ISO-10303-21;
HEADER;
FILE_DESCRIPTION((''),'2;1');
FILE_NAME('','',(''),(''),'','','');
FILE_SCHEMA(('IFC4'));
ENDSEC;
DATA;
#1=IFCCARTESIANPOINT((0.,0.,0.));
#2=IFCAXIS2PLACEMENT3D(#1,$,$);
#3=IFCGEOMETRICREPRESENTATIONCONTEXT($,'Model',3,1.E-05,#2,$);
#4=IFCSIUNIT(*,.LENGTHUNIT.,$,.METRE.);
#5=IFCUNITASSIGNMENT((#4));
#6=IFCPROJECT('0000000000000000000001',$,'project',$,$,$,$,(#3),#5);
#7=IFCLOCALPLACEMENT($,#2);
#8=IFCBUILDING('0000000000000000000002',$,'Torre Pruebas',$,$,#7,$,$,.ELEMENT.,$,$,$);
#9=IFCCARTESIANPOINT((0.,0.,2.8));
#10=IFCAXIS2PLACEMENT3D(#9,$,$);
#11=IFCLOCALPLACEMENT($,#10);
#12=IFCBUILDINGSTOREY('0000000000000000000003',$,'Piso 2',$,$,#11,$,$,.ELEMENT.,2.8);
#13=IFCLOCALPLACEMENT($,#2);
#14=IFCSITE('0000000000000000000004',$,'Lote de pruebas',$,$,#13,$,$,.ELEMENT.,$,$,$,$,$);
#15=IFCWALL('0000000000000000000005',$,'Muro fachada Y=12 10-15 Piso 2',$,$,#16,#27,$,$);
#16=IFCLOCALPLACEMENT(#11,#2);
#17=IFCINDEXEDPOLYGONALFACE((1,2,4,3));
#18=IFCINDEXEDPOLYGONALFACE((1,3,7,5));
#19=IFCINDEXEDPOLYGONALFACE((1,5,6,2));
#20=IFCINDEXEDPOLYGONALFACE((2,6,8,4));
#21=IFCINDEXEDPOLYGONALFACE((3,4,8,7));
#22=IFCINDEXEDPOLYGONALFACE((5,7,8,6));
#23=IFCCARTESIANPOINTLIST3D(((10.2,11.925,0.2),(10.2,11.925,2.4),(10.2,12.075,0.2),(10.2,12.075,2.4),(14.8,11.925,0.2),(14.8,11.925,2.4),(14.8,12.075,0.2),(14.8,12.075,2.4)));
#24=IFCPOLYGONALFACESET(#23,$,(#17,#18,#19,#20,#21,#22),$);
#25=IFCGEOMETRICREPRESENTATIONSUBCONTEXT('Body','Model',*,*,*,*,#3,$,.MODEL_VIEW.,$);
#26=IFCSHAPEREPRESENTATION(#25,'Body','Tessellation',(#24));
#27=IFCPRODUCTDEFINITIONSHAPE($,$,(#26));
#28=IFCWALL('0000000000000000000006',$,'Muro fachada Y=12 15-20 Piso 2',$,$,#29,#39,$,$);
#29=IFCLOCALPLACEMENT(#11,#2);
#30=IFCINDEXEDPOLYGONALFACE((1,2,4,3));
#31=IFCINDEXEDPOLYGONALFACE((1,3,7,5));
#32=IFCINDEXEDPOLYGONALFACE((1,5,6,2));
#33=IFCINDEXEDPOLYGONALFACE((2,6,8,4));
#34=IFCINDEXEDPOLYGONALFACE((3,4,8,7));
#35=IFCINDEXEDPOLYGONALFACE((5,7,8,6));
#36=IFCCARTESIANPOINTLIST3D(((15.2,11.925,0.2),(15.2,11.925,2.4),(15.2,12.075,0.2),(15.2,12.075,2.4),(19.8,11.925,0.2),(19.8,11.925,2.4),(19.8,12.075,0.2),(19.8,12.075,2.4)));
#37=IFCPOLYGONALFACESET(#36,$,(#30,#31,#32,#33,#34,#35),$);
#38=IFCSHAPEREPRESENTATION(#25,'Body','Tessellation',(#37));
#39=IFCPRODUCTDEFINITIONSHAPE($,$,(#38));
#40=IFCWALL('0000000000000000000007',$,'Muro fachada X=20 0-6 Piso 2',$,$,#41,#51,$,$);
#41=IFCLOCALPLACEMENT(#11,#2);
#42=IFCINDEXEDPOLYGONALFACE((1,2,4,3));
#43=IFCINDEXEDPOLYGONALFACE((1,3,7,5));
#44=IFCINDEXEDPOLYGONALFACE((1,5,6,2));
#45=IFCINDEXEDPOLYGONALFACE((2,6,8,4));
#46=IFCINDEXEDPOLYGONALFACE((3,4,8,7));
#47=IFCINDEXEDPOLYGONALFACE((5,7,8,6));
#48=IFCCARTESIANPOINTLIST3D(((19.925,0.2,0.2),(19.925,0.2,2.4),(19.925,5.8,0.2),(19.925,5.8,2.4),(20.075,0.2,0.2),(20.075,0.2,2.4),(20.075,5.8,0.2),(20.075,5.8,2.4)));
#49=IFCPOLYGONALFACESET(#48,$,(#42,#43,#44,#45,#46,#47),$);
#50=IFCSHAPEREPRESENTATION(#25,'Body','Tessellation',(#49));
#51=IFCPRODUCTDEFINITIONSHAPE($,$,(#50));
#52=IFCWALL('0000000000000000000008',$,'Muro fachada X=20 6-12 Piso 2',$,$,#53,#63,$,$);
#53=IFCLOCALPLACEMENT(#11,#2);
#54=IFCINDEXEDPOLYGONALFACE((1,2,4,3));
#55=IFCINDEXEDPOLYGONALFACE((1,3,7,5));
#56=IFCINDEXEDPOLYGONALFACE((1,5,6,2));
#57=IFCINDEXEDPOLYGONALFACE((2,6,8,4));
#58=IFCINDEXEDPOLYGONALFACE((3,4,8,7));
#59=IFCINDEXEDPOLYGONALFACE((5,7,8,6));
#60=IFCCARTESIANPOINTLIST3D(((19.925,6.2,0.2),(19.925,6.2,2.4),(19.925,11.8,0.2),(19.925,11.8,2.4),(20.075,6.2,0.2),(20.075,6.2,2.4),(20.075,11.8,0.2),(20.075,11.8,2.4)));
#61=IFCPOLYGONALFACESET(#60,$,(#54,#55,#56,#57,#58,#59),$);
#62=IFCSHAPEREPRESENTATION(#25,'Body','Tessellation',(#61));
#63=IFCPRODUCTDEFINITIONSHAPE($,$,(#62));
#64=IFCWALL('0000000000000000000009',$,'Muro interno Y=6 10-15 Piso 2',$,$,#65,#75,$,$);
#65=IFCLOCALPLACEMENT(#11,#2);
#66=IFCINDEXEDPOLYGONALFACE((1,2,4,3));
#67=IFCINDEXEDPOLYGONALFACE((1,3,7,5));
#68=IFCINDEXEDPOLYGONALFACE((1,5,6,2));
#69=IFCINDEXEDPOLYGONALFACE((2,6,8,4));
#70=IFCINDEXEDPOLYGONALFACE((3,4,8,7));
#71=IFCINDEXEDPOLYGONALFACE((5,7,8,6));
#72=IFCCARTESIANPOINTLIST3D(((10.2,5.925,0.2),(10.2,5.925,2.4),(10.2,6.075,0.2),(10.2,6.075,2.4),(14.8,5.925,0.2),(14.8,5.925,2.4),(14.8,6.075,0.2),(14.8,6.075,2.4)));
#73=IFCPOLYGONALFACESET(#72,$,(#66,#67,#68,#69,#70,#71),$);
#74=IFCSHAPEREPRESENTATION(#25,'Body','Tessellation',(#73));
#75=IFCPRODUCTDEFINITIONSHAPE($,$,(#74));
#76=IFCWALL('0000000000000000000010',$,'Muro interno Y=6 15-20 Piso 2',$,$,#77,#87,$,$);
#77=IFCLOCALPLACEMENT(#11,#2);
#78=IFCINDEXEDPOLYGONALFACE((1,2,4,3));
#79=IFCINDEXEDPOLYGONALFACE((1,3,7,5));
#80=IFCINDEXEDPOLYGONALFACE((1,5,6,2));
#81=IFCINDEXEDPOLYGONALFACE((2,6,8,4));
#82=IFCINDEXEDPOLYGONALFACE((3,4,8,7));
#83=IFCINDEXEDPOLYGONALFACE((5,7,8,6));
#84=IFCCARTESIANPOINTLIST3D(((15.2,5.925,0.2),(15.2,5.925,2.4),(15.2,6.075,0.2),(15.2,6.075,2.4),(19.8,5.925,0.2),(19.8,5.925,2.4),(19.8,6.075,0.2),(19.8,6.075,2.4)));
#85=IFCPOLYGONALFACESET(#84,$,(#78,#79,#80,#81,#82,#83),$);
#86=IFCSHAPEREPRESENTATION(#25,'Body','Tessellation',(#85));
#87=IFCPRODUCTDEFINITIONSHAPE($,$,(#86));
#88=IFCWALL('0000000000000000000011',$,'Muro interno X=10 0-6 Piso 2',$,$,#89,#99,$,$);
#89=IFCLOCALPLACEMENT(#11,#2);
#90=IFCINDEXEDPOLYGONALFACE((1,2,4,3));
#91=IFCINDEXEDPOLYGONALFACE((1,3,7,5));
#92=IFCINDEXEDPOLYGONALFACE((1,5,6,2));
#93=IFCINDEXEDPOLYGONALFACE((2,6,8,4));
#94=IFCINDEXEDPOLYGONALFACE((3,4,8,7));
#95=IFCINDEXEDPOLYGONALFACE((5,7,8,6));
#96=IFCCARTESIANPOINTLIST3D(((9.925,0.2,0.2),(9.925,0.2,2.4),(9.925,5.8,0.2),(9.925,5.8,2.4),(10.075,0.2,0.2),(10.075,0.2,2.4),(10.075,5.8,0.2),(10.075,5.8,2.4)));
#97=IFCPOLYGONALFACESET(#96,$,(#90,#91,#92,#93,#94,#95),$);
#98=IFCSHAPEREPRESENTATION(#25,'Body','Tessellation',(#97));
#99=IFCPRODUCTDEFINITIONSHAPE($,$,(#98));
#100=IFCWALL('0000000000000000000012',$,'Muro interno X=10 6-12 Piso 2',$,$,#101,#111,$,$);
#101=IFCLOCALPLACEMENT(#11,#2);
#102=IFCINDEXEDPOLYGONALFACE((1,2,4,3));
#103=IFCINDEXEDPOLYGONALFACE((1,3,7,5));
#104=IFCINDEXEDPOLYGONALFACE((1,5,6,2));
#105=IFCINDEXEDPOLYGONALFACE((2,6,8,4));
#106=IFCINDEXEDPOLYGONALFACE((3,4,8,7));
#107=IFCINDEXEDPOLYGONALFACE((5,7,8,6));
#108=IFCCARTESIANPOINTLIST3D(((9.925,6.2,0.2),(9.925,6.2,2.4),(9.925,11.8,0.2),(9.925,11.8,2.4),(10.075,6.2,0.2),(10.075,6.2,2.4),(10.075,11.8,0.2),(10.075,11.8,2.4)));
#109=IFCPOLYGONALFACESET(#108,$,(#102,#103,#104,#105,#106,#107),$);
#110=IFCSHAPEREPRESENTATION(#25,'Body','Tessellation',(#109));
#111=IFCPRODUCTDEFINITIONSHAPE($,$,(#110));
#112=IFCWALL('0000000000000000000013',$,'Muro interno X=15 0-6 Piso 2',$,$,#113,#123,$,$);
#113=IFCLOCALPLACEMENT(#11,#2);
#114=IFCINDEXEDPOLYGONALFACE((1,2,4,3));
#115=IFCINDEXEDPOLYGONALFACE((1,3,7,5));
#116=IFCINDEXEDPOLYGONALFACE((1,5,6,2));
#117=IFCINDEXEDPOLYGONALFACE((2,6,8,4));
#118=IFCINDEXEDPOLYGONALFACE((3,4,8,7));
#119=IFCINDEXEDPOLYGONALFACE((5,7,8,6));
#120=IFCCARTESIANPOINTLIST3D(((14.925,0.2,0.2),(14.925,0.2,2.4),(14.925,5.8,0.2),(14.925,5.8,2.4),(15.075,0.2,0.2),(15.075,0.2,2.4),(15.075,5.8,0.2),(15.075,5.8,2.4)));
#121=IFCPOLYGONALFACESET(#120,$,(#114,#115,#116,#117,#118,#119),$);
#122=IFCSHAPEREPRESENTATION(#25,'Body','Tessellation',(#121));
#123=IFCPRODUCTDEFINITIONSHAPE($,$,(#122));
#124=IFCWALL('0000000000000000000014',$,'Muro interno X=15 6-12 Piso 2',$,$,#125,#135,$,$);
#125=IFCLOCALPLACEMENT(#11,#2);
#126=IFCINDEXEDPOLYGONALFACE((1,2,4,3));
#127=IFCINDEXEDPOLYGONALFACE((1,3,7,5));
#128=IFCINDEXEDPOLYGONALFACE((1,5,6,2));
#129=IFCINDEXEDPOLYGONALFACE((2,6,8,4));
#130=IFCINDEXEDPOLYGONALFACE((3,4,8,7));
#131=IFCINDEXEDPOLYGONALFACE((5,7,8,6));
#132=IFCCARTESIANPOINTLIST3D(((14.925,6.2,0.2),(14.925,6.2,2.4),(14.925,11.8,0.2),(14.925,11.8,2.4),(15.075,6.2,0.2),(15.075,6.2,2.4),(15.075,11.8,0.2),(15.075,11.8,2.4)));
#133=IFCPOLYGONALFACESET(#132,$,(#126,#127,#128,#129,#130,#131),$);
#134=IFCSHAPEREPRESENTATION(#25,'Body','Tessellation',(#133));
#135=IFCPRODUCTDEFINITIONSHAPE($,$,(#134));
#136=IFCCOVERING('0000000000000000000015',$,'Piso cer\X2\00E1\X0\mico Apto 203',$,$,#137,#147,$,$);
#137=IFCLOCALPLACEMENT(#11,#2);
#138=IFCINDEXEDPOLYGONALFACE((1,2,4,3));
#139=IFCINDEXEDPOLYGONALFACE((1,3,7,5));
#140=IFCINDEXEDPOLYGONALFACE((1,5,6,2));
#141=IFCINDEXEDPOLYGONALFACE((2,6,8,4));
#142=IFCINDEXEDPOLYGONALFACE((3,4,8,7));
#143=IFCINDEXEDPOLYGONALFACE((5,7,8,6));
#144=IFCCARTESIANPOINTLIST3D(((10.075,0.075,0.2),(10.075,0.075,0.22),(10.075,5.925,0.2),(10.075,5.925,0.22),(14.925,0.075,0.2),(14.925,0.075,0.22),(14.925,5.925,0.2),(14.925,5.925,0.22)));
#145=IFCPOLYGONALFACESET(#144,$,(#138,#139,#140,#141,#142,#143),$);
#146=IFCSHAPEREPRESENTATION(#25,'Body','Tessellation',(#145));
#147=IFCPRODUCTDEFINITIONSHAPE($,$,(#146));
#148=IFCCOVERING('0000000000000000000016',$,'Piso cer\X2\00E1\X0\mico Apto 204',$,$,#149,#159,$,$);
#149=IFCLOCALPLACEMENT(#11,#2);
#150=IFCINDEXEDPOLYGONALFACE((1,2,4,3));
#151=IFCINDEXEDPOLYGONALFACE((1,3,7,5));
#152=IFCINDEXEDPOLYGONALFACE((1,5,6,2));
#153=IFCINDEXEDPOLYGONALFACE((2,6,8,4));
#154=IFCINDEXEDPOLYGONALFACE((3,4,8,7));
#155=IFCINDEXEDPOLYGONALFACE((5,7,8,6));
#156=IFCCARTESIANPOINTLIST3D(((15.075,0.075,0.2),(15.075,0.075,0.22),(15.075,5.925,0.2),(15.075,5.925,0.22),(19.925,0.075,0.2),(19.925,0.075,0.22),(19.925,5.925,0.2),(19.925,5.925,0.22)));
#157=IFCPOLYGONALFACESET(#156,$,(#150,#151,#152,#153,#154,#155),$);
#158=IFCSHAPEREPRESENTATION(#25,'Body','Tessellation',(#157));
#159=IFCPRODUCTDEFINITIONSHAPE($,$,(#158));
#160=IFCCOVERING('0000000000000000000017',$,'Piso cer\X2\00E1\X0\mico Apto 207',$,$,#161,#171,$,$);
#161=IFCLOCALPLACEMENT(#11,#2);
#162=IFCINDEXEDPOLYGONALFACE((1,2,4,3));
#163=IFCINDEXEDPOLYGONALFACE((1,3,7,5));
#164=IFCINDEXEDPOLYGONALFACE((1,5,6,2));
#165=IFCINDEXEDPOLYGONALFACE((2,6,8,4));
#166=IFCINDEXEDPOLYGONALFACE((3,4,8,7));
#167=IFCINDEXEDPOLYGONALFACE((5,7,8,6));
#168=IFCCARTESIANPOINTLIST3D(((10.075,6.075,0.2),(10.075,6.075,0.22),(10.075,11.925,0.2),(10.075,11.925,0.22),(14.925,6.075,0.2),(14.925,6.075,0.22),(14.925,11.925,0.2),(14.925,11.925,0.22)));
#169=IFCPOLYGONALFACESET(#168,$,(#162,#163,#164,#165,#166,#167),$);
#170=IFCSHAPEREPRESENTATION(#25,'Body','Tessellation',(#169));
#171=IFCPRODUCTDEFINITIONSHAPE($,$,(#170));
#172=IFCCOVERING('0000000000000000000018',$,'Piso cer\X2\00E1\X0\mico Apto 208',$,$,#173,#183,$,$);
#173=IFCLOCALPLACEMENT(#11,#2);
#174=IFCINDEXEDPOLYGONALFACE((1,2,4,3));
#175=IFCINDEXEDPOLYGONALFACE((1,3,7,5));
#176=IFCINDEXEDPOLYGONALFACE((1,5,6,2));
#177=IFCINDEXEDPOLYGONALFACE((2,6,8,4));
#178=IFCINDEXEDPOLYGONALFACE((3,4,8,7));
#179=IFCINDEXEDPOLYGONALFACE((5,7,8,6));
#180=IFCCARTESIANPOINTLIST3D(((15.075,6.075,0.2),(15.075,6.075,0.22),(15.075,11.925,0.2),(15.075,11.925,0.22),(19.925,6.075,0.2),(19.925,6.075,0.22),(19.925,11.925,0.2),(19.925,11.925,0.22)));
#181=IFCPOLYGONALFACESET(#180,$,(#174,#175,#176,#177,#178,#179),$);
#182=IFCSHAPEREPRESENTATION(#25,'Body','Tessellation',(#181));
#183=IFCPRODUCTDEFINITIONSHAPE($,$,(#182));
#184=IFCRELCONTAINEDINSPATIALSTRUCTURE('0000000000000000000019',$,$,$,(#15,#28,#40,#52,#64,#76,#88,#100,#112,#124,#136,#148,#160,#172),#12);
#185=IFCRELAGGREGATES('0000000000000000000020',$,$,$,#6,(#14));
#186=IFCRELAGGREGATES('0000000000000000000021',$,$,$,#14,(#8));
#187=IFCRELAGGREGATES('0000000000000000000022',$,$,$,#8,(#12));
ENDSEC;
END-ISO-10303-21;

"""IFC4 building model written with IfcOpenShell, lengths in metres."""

from ifc_helpers import new_model, si_unit, frame, origin, origin_2d, place, context, subcontext, project, spatial, rectangle, extrude, element, save


model = new_model("IFC4")

# Units and contexts
model_context = context("Model", 3, precision=1e-05, world=origin())
body_context = subcontext(model_context, "Body", "Model", "MODEL_VIEW")
ifc_project = project(units=[si_unit("LENGTHUNIT", "METRE")], contexts=[model_context])

# Site, building, storey
site_placement = place(None, origin())
site = spatial("IfcSite", under=ifc_project, at=site_placement, Name="Lote de pruebas", CompositionType="ELEMENT")
building_placement = place(None, origin())
building = spatial("IfcBuilding", under=site, at=building_placement, Name="Torre Pruebas", CompositionType="ELEMENT")
storey_placement = place(None, frame((0.0, 0.0, 2.8)))
storey = spatial("IfcBuildingStorey", under=building, at=storey_placement, Name="Piso 2", CompositionType="ELEMENT", Elevation=2.8)

# Walls
for number, where, name in (
    (1, (12.5, 12.0, 3.0), "Muro fachada Y=12 10-15 Piso 2"),
    (2, (17.5, 12.0, 3.0), "Muro fachada Y=12 15-20 Piso 2"),
):
    element("IfcWall", number, at=place(None, frame(where)), inside=storey, Name=name, context=body_context, shape_type="SweptSolid", body=[
        extrude(rectangle(XDim=4.6, YDim=0.15, at=origin_2d()), origin(), (0.0, 0.0, 1.0), 2.2),
    ])
for number, where, name in (
    (3, (20.0, 3.0, 3.0), "Muro fachada X=20 0-6 Piso 2"),
    (4, (20.0, 9.0, 3.0), "Muro fachada X=20 6-12 Piso 2"),
):
    element("IfcWall", number, at=place(None, frame(where)), inside=storey, Name=name, context=body_context, shape_type="SweptSolid", body=[
        extrude(rectangle(XDim=0.15, YDim=5.6, at=origin_2d()), origin(), (0.0, 0.0, 1.0), 2.2),
    ])
for number, where, name in (
    (5, (12.5, 6.0, 3.0), "Muro interno Y=6 10-15 Piso 2"),
    (6, (17.5, 6.0, 3.0), "Muro interno Y=6 15-20 Piso 2"),
):
    element("IfcWall", number, at=place(None, frame(where)), inside=storey, Name=name, context=body_context, shape_type="SweptSolid", body=[
        extrude(rectangle(XDim=4.6, YDim=0.15, at=origin_2d()), origin(), (0.0, 0.0, 1.0), 2.2),
    ])
for number, where, name in (
    (7, (10.0, 3.0, 3.0), "Muro interno X=10 0-6 Piso 2"),
    (8, (10.0, 9.0, 3.0), "Muro interno X=10 6-12 Piso 2"),
    (9, (15.0, 3.0, 3.0), "Muro interno X=15 0-6 Piso 2"),
    (10, (15.0, 9.0, 3.0), "Muro interno X=15 6-12 Piso 2"),
):
    element("IfcWall", number, at=place(None, frame(where)), inside=storey, Name=name, context=body_context, shape_type="SweptSolid", body=[
        extrude(rectangle(XDim=0.15, YDim=5.6, at=origin_2d()), origin(), (0.0, 0.0, 1.0), 2.2),
    ])

# Coverings
for number, where, name in (
    (11, (12.5, 3.0, 3.0), "Piso cerámico Apto 203"),
    (12, (17.5, 3.0, 3.0), "Piso cerámico Apto 204"),
    (13, (12.5, 9.0, 3.0), "Piso cerámico Apto 207"),
    (14, (17.5, 9.0, 3.0), "Piso cerámico Apto 208"),
):
    element("IfcCovering", number, at=place(None, frame(where)), inside=storey, Name=name, context=body_context, shape_type="SweptSolid", body=[
        extrude(rectangle(XDim=4.85, YDim=5.85, at=origin_2d()), origin(), (0.0, 0.0, 1.0), 0.02),
    ])

save(model, "model.ifc")
